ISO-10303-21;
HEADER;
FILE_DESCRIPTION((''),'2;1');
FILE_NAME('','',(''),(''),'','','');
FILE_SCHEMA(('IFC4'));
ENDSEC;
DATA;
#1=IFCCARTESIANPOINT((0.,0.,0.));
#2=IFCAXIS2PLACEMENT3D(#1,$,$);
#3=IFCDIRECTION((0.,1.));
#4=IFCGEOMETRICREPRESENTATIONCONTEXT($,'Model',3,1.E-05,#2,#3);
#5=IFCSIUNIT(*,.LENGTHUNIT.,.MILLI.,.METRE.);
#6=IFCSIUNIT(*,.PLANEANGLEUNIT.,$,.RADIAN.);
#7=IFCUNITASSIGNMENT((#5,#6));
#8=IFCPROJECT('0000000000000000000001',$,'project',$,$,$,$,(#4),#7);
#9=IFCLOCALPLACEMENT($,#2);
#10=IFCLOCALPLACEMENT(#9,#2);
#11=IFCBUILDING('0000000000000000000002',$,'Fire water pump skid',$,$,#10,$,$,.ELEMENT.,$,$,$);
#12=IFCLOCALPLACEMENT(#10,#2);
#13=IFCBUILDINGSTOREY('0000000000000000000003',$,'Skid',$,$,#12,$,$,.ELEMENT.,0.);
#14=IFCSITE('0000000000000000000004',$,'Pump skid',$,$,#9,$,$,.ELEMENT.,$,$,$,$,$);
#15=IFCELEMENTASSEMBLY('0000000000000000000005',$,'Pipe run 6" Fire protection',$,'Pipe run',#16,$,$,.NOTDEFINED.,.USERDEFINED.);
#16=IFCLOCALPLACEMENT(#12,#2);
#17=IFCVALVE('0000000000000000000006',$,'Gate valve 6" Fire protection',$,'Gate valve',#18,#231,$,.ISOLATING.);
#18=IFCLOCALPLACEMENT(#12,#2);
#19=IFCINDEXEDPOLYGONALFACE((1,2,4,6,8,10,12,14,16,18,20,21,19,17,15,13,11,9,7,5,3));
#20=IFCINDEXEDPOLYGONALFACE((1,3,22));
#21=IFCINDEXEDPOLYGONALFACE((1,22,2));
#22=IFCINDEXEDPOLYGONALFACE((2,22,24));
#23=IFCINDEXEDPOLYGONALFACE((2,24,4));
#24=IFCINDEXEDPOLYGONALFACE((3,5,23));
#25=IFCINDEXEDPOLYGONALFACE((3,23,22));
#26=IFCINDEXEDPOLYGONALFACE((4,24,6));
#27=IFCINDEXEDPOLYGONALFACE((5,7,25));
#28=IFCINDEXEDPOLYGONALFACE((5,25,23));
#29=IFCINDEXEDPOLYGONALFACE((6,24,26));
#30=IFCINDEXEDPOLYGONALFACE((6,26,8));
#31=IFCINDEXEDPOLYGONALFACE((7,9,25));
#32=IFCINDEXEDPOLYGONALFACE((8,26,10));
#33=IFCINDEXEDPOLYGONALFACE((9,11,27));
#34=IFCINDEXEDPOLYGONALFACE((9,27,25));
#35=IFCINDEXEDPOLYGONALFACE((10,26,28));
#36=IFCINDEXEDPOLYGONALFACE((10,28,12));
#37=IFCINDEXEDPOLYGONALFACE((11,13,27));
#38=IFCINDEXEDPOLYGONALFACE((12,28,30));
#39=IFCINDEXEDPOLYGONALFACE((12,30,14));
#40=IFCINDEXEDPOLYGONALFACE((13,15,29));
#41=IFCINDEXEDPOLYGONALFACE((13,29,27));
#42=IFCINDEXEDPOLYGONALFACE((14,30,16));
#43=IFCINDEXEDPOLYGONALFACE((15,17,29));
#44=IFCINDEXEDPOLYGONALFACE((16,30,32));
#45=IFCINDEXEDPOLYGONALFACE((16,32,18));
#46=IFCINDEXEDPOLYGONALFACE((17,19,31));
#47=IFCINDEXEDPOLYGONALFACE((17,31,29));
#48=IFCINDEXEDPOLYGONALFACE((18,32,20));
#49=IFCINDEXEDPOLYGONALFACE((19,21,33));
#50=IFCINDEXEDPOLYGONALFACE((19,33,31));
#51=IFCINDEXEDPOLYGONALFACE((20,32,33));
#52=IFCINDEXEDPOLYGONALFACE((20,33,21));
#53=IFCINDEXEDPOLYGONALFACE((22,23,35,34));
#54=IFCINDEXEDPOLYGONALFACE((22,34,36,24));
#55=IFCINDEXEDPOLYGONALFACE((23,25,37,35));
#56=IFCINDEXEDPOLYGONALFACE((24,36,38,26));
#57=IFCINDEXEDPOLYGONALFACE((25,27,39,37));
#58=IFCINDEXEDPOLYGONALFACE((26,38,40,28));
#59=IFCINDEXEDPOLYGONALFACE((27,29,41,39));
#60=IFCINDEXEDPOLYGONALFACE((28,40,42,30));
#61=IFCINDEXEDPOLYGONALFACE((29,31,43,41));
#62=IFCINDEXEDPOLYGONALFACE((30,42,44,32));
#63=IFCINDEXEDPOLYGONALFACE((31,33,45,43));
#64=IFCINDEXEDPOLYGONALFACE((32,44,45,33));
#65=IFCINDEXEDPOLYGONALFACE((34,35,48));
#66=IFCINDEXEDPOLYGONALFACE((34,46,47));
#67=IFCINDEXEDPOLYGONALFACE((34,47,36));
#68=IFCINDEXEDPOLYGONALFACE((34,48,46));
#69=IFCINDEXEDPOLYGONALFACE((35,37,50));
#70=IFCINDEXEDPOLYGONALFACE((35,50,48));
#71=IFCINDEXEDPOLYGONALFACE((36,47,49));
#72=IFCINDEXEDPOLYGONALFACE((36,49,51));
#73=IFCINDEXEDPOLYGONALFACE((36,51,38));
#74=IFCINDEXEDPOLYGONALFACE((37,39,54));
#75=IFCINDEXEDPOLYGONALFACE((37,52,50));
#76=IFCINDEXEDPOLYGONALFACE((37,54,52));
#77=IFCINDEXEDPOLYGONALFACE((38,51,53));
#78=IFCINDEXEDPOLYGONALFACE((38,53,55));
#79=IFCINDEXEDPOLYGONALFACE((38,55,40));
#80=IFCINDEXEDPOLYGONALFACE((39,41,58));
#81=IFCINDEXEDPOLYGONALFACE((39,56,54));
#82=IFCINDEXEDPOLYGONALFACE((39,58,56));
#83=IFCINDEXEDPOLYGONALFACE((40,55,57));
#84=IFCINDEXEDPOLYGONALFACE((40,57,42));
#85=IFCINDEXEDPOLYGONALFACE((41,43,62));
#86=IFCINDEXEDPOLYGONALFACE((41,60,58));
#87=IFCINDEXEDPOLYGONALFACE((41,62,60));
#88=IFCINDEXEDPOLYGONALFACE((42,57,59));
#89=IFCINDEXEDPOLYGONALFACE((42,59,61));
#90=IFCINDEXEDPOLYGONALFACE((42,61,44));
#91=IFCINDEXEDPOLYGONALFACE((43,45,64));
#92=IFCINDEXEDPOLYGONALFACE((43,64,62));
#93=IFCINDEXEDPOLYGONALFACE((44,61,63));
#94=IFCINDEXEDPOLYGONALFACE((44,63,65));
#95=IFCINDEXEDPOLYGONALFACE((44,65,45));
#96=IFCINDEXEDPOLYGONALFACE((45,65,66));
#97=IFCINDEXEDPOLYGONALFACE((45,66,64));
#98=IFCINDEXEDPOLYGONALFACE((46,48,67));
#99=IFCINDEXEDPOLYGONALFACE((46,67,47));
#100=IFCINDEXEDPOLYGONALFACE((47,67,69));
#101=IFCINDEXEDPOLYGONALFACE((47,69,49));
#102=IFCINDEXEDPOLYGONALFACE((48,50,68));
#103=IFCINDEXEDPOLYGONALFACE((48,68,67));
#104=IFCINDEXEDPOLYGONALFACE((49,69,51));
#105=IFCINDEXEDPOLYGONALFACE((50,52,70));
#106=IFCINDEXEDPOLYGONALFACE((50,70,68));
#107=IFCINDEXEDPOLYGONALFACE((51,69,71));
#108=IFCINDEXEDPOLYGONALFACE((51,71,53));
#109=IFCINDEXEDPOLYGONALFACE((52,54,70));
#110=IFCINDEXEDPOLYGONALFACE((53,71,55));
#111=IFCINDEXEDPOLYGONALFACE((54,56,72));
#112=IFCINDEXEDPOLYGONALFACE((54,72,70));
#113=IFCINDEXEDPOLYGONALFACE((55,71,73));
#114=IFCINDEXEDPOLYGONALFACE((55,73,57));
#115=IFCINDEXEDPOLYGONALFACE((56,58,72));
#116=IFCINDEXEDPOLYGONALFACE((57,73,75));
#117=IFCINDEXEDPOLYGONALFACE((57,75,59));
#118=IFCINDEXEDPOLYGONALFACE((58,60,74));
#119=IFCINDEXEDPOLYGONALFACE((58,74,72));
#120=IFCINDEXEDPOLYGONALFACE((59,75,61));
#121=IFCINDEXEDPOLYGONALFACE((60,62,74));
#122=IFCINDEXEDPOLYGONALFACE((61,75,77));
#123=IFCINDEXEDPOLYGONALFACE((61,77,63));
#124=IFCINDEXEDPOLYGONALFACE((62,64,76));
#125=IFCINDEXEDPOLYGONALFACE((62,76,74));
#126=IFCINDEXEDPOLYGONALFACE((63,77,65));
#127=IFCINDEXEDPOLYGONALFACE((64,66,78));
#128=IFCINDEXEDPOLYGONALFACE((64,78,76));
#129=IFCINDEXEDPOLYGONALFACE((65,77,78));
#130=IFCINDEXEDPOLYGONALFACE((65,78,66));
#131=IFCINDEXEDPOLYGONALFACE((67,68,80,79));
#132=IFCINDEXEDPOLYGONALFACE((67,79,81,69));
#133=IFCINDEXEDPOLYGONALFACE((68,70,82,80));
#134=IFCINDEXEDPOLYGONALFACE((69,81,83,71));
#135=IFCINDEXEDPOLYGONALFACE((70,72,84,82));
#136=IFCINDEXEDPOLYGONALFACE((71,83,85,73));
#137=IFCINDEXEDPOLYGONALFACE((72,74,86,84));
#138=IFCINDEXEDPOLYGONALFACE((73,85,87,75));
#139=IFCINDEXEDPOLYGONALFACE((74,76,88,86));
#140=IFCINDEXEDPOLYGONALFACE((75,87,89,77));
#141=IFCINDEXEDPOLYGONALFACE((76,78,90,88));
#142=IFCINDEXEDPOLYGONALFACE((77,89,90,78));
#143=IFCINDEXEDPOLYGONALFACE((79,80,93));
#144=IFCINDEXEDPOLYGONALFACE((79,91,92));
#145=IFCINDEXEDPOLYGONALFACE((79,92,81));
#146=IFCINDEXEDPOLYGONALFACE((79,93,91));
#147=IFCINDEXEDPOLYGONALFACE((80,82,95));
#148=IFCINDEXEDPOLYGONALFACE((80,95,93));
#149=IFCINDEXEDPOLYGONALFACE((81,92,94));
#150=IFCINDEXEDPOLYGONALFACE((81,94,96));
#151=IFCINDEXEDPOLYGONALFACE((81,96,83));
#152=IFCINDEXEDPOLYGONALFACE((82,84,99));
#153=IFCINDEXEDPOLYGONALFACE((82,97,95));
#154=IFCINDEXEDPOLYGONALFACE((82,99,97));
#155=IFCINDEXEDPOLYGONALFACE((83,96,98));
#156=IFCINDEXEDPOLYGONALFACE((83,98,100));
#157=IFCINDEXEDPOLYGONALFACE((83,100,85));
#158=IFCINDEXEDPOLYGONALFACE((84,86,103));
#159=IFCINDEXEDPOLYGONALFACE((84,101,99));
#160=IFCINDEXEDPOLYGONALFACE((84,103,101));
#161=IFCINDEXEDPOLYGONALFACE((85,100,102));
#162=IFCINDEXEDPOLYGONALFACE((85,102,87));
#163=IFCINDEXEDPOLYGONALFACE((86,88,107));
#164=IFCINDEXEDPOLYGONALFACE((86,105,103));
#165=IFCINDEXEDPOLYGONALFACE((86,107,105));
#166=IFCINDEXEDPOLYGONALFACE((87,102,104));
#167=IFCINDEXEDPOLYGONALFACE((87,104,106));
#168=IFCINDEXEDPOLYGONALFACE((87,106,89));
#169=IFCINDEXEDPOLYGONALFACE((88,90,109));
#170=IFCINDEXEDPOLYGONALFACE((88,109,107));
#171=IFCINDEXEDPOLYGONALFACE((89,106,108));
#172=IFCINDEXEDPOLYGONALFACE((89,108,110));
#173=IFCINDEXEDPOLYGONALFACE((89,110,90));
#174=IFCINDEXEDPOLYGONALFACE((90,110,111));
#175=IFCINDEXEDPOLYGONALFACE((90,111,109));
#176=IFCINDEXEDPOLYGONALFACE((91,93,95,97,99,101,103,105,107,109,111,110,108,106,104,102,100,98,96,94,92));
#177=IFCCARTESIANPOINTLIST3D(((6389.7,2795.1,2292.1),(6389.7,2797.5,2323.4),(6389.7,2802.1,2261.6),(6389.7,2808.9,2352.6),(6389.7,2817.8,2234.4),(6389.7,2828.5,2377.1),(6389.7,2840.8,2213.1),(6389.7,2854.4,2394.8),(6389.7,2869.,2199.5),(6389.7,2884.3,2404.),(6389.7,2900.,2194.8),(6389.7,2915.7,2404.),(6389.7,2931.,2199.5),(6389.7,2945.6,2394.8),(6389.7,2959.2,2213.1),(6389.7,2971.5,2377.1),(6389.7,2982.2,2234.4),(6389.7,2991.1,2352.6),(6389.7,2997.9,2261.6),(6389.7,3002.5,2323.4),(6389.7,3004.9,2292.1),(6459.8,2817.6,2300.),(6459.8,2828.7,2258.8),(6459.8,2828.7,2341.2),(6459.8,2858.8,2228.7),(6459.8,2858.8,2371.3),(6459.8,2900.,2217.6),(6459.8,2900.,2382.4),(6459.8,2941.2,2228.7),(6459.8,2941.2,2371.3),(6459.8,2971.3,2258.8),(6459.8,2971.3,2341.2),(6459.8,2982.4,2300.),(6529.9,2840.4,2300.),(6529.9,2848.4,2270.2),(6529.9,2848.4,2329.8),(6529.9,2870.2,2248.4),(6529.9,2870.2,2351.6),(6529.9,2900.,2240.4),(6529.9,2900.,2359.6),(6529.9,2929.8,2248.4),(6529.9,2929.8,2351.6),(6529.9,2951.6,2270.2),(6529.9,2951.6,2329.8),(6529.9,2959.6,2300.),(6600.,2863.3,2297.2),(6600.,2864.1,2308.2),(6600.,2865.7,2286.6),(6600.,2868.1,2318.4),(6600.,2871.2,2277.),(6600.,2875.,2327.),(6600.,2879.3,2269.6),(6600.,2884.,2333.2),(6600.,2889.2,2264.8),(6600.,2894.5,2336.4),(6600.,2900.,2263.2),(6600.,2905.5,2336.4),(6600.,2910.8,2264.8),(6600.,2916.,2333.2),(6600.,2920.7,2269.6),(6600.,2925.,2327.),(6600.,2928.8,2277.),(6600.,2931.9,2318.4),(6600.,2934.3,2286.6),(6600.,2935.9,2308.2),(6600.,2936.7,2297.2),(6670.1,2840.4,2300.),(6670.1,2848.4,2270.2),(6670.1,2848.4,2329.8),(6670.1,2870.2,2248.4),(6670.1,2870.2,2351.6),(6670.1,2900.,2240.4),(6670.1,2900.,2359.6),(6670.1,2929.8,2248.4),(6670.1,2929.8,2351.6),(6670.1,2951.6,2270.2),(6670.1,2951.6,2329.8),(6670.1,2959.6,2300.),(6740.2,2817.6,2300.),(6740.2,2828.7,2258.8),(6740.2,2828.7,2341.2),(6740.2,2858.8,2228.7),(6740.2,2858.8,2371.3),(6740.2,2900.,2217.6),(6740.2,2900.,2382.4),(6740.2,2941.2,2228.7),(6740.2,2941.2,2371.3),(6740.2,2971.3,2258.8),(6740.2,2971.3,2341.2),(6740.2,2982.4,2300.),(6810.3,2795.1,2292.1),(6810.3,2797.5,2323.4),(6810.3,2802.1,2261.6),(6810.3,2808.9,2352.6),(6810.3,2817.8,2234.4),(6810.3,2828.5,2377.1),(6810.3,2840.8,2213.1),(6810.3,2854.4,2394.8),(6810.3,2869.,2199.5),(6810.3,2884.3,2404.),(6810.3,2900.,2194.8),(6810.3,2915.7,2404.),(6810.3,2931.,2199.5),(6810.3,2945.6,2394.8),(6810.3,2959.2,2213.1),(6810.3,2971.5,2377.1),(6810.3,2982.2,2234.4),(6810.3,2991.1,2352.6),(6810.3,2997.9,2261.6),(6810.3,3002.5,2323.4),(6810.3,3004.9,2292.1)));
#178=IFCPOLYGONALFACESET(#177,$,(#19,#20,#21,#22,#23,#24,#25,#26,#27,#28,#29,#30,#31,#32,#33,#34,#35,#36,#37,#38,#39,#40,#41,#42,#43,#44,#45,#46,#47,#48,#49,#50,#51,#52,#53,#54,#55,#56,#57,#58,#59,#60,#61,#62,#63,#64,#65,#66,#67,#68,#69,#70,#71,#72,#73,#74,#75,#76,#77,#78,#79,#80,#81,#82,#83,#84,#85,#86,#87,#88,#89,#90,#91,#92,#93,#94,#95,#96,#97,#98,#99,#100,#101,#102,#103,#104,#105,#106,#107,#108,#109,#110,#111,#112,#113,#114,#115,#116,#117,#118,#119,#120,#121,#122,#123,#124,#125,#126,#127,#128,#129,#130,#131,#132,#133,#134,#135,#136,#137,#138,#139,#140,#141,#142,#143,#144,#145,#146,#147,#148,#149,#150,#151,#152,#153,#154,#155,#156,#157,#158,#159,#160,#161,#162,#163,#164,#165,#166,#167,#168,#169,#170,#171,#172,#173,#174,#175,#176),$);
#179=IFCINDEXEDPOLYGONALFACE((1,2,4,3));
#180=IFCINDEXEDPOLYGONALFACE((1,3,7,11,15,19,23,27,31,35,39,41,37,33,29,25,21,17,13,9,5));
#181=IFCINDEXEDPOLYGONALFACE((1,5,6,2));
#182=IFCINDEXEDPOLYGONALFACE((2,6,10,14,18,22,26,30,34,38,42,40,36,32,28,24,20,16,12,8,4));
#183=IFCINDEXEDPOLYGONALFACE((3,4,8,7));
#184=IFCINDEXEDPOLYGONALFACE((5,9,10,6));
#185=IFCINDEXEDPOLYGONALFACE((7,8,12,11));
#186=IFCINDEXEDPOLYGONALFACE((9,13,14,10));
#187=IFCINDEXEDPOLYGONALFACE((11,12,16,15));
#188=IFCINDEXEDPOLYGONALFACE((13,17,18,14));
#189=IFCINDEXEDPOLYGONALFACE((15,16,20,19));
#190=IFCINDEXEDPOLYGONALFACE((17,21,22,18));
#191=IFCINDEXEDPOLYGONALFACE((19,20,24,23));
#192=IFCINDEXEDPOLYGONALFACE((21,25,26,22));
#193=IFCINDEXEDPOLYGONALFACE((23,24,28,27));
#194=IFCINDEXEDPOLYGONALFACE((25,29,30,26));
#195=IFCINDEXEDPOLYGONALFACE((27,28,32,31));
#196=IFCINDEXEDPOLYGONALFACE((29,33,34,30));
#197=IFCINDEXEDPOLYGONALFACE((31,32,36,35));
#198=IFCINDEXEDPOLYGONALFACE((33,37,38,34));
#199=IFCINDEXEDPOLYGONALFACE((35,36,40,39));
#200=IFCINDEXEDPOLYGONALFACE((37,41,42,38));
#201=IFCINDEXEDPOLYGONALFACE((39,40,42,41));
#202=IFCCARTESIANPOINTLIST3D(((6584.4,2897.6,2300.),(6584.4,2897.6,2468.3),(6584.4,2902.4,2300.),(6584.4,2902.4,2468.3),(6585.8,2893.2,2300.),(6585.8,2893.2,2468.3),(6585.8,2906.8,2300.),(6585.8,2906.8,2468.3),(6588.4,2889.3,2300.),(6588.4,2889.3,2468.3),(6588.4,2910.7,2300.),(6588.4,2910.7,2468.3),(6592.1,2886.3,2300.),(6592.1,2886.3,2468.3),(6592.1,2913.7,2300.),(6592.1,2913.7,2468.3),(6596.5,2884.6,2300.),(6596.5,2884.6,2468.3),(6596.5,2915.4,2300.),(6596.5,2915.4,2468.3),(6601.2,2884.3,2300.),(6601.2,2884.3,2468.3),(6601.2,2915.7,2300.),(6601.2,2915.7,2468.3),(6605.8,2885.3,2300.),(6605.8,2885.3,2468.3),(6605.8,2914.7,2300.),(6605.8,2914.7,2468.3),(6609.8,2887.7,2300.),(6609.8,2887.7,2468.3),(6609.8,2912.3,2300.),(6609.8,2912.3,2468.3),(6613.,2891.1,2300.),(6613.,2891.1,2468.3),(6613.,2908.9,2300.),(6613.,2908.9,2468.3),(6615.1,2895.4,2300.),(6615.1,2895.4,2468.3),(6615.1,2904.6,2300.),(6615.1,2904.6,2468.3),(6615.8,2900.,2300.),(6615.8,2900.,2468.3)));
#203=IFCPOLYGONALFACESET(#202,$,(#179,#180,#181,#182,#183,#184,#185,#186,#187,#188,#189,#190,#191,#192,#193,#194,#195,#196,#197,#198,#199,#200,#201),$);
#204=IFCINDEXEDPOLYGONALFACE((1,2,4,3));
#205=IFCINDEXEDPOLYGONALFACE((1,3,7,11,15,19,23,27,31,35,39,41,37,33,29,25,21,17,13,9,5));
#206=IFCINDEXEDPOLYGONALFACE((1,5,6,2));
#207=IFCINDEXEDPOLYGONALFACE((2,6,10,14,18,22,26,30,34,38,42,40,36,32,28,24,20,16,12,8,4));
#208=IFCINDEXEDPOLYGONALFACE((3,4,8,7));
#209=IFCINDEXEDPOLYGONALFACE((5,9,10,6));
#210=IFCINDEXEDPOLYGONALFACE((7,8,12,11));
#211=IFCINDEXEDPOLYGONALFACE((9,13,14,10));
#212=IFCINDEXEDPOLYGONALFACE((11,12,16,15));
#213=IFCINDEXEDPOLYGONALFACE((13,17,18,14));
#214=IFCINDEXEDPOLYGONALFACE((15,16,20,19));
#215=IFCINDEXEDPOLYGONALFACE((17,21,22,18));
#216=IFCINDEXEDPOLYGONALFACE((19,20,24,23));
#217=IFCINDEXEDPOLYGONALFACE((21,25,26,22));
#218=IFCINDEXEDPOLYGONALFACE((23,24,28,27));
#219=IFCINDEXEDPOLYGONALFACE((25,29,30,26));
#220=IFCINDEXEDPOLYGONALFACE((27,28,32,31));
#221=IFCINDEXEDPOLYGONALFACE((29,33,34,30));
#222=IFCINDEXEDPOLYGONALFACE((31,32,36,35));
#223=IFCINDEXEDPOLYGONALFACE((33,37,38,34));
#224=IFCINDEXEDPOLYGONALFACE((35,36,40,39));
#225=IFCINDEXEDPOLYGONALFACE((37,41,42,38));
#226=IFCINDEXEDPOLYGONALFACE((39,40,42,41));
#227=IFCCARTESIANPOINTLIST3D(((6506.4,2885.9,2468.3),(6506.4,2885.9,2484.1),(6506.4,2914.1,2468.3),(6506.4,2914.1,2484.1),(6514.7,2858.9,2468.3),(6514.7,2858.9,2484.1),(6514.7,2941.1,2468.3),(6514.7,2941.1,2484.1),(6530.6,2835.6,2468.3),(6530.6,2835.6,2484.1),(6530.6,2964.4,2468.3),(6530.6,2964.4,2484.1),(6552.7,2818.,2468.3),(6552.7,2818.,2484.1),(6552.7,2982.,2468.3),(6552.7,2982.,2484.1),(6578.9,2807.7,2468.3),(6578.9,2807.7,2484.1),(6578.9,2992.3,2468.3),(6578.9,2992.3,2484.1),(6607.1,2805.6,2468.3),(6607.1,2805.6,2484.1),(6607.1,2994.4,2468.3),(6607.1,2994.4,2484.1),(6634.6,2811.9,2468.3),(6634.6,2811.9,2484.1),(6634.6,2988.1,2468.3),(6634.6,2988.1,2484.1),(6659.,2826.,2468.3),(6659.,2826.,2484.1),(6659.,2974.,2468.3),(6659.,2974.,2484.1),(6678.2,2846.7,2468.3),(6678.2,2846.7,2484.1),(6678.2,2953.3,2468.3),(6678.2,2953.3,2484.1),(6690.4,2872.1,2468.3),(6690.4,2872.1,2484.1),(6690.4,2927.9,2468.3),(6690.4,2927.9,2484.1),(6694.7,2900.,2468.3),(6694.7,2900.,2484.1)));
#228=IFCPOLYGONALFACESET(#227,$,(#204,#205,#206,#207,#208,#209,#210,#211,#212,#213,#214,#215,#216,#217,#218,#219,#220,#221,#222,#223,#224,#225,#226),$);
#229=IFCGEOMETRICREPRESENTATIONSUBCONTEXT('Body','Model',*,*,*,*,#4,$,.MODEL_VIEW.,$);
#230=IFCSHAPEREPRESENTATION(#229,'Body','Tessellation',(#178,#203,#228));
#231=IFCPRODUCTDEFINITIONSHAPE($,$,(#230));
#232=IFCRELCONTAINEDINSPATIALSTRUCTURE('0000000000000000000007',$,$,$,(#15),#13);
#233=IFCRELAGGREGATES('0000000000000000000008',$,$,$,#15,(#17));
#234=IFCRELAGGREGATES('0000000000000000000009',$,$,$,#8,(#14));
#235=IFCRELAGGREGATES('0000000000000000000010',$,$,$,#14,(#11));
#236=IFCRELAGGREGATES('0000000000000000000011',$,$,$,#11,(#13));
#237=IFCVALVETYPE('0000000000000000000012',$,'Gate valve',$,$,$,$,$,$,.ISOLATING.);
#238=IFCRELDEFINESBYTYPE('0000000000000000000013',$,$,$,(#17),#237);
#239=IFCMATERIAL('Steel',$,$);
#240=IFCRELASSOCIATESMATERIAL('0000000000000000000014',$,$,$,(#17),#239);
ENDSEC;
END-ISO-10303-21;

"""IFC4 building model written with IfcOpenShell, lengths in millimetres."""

from ifc_helpers import new_model, entity, si_unit, direction, frame, origin, origin_with_axes, origin_2d, place, context, subcontext, project, spatial, circle, extrude, material, type_object, element, aggregate, save


model = new_model("IFC4")

# Units and contexts
model_context = context("Model", 3, precision=1e-05, world=origin(), true_north=direction((0.0, 1.0)))
body_context = subcontext(model_context, "Body", "Model", "MODEL_VIEW")
ifc_project = project(units=[si_unit("LENGTHUNIT", "METRE", prefix="MILLI"), si_unit("PLANEANGLEUNIT", "RADIAN")], contexts=[model_context])

# Site, building, storey
site_placement = place(None, origin())
site = spatial("IfcSite", under=ifc_project, at=site_placement, Name="Pump skid", CompositionType="ELEMENT")
building_placement = place(site_placement, origin())
building = spatial("IfcBuilding", under=site, at=building_placement, Name="Fire water pump skid", CompositionType="ELEMENT")
storey_placement = place(building_placement, origin())
storey = spatial("IfcBuildingStorey", under=building, at=storey_placement, Name="Skid", CompositionType="ELEMENT", Elevation=0.0)

# Element assembly
ifc_material = material(Name="Steel")
assembly_1_placement = place(storey_placement, origin_with_axes())
assembly_1 = element("IfcElementAssembly", 1, at=assembly_1_placement, inside=storey, Name="Pipe run 6\" Fire protection", ObjectType="Pipe run", AssemblyPlace="NOTDEFINED", PredefinedType="USERDEFINED")

# Valve
valve_type_1 = type_object("IfcValveType", Name="Gate valve", PredefinedType="ISOLATING")
valve_1_placement = place(storey_placement, origin_with_axes())
cartesian_point_1 = entity("IfcCartesianPoint", [0.0, 0.0])
valve_1 = element("IfcValve", 2, at=valve_1_placement, type_object=valve_type_1, material=ifc_material, Name="Gate valve 6\" Fire protection", ObjectType="Gate valve", PredefinedType="ISOLATING", context=body_context, shape_type="SweptSolid", body=[
    entity("IfcRevolvedAreaSolid", entity("IfcArbitraryClosedProfileDef", "AREA", None, entity("IfcPolyline", [cartesian_point_1, entity("IfcCartesianPoint", [0.0, 105.2]), entity("IfcCartesianPoint", [210.3, 36.8]), entity("IfcCartesianPoint", [420.7, 105.2]), entity("IfcCartesianPoint", [420.7, 0.0]), cartesian_point_1])), entity("IfcAxis2Placement3D", entity("IfcCartesianPoint", [6389.7, 2900.0, 2300.0]), entity("IfcDirection", [0.0, 1.0, 0.0]), entity("IfcDirection", [1.0, 0.0, 0.0])), entity("IfcAxis1Placement", entity("IfcCartesianPoint", [0.0, 0.0, 0.0]), entity("IfcDirection", [1.0, 0.0, 0.0])), 6.283185),
    extrude(circle(Radius=15.8, at=origin_2d()), frame((6600.0, 2900.0, 2300.0), z_axis=(0.0, 0.0, 1.0), x_axis=(1.0, 0.0, 0.0)), (0.0, 0.0, 1.0), 168.3),
    extrude(circle(Radius=94.7, at=origin_2d()), frame((6600.0, 2900.0, 2468.3), z_axis=(0.0, 0.0, 1.0), x_axis=(1.0, 0.0, 0.0)), (0.0, 0.0, 1.0), 15.8),
])

aggregate(assembly_1, [valve_1])

save(model, "model.ifc")
